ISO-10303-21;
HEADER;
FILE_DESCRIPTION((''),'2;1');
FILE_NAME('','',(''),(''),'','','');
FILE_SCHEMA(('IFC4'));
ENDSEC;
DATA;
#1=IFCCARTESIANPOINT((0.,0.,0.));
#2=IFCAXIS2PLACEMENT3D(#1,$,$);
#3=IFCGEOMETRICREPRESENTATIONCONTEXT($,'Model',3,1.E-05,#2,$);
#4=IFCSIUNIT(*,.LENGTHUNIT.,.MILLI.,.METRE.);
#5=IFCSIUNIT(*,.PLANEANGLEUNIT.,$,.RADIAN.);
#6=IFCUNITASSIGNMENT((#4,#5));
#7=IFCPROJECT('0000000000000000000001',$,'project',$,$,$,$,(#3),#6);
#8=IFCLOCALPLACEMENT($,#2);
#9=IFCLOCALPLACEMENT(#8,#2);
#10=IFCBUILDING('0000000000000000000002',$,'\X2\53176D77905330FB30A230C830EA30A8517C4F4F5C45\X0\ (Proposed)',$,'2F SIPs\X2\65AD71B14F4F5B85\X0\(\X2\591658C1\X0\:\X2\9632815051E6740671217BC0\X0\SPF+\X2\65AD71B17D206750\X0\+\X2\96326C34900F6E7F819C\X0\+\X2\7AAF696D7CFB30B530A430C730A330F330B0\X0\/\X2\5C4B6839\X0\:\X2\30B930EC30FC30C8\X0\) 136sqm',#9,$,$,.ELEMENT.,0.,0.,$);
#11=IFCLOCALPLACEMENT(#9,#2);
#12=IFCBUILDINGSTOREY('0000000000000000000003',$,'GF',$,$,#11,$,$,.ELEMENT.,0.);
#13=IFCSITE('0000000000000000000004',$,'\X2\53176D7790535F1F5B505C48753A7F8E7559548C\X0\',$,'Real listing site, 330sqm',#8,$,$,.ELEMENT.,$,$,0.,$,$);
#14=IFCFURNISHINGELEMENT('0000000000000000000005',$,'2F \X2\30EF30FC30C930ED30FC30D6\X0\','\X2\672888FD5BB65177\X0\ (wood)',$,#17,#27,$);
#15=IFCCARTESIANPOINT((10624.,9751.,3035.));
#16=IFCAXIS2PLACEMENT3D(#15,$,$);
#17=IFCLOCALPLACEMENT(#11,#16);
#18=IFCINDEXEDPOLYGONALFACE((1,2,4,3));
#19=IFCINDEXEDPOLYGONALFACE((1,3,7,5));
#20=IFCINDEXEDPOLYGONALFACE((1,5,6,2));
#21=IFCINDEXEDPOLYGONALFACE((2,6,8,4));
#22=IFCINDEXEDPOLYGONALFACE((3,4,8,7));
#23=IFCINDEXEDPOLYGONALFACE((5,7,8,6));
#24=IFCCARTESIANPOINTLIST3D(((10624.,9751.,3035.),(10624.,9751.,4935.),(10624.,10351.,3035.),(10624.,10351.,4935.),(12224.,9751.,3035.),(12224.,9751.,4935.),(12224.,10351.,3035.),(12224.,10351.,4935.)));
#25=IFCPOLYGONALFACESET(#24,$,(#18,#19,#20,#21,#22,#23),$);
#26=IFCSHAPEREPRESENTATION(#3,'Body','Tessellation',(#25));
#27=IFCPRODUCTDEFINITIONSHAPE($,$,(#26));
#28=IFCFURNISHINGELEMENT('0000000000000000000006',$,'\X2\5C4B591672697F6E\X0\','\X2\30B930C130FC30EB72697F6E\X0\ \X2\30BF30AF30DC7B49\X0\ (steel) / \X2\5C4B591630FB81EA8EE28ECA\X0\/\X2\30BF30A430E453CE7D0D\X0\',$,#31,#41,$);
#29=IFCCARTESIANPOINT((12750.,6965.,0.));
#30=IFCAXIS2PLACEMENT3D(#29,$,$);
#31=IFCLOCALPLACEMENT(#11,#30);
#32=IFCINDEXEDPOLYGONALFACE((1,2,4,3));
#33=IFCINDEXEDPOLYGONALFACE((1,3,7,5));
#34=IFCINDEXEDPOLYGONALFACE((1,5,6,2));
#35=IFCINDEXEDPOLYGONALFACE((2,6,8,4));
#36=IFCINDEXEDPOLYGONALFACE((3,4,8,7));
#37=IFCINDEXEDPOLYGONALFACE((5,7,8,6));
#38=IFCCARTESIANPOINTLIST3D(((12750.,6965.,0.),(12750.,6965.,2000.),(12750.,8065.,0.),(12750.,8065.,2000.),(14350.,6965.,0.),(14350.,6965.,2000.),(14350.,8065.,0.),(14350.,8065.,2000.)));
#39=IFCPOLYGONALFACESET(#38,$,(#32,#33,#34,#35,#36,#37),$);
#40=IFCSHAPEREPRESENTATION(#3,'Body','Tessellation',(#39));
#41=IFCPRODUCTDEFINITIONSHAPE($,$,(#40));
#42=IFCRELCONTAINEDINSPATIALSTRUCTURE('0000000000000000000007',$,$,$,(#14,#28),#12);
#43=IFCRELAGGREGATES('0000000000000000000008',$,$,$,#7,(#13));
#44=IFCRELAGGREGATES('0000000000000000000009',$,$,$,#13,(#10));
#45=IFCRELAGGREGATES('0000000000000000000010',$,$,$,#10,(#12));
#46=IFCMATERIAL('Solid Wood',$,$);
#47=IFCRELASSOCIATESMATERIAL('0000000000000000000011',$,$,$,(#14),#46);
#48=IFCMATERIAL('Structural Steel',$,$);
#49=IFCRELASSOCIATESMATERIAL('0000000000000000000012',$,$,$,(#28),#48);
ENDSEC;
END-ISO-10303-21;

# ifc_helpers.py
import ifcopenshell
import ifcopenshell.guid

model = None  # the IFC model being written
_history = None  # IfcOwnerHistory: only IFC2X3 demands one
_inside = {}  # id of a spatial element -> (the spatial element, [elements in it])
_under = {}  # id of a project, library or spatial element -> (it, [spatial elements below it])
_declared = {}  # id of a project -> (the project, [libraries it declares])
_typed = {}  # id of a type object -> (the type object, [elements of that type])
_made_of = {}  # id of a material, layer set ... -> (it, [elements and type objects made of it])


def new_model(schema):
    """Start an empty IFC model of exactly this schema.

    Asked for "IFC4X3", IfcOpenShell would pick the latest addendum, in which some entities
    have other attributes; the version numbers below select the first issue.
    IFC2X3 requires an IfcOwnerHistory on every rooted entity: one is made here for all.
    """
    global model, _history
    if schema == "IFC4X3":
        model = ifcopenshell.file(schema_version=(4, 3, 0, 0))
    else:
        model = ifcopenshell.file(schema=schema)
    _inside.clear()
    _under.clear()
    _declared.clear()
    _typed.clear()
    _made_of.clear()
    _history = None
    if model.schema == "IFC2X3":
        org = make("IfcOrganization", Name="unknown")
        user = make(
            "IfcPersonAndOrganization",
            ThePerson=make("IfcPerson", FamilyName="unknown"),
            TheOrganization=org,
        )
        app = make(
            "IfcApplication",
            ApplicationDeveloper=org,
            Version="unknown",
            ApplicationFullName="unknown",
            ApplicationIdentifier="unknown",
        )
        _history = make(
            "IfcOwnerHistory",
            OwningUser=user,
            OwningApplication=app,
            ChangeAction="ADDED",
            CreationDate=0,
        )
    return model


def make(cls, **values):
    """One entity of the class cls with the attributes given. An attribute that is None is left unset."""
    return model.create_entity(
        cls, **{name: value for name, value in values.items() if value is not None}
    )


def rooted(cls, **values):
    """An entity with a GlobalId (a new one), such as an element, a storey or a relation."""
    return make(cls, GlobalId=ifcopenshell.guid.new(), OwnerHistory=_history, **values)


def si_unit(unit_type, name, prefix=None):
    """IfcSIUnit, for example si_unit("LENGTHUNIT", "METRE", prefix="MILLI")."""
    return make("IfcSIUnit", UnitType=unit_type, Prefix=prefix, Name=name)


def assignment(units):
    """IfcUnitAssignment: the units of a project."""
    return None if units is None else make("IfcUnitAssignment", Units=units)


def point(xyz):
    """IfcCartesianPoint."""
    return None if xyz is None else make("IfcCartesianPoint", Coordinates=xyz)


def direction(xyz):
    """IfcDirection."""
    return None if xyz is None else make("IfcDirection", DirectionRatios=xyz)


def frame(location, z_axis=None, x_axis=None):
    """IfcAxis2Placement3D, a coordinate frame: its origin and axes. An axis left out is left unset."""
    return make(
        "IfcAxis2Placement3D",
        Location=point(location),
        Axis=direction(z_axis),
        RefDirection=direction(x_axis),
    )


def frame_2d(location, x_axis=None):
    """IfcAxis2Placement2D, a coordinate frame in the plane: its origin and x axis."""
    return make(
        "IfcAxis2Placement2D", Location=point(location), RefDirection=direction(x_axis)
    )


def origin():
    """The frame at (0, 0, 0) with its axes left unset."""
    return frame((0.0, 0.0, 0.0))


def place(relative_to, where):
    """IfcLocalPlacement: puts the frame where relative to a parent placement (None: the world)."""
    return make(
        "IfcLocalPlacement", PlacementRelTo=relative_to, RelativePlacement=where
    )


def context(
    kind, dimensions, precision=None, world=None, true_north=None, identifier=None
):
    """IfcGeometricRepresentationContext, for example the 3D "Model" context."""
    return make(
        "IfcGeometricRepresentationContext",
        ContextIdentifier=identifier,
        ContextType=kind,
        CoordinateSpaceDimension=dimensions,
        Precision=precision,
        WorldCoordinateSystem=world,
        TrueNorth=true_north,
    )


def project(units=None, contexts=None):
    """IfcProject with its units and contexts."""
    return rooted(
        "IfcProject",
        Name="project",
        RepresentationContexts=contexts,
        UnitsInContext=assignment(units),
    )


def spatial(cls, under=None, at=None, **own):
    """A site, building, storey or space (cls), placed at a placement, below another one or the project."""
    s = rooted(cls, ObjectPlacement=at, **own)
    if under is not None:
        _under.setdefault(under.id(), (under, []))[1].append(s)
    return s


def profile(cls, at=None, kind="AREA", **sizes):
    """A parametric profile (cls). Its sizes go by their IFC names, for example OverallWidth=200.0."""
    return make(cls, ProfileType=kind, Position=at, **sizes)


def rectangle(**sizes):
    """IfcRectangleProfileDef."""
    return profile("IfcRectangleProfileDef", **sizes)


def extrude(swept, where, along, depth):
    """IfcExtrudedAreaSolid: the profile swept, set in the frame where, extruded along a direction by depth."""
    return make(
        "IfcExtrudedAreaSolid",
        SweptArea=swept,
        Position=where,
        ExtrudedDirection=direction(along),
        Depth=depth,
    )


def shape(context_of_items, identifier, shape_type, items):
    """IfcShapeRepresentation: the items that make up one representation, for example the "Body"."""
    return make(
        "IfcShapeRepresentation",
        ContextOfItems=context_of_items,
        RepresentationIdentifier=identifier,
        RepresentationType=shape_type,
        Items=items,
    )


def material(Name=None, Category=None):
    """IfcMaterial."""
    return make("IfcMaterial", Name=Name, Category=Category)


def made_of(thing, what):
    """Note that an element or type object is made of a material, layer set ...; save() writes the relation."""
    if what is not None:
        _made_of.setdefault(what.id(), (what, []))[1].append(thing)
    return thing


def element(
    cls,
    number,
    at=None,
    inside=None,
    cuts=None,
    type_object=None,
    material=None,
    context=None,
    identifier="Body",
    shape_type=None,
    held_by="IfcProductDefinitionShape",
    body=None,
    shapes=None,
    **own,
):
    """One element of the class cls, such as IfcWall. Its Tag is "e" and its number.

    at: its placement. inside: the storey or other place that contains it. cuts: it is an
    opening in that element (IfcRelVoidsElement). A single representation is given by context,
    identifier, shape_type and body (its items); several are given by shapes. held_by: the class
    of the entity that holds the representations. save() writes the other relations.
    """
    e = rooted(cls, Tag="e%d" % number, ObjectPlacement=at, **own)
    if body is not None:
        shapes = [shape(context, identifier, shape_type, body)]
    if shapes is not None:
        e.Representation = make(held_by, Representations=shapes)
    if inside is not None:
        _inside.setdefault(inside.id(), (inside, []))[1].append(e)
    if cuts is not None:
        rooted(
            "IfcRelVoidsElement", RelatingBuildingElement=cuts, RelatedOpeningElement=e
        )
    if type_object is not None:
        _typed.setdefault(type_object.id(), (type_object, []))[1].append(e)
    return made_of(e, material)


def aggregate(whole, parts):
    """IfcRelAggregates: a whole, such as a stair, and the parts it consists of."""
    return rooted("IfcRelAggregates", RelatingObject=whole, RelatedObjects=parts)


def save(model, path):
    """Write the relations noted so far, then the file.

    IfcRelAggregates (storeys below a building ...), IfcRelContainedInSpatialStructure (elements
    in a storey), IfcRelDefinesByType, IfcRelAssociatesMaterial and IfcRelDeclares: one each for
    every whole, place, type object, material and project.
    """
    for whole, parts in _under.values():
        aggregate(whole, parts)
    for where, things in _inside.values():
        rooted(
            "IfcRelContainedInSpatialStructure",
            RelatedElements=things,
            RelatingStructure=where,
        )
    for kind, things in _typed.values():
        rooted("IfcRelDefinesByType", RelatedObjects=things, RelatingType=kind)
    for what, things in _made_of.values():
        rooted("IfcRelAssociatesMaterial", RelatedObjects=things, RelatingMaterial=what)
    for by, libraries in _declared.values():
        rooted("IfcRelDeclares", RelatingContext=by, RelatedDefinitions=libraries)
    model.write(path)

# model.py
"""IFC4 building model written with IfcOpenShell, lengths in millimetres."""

from ifc_helpers import new_model, si_unit, frame, frame_2d, origin, place, context, project, spatial, rectangle, extrude, material, element, save


model = new_model("IFC4")

# Units and contexts
model_context = context("Model", 3, precision=1e-05, world=origin())
ifc_project = project(units=[si_unit("LENGTHUNIT", "METRE", prefix="MILLI"), si_unit("PLANEANGLEUNIT", "RADIAN")], contexts=[model_context])

# Site, building, storey
site_placement = place(None, origin())
site = spatial("IfcSite", under=ifc_project, at=site_placement, Name="北海道弟子屈町美留和", ObjectType="Real listing site, 330sqm", CompositionType="ELEMENT", RefElevation=0.0)
building_placement = place(site_placement, origin())
building = spatial("IfcBuilding", under=site, at=building_placement, Name="北海道・アトリエ兼住居 (Proposed)", ObjectType="2F SIPs断熱住宅(外壁:防腐処理無節SPF+断熱素材+防水透湿膜+窯業系サイディング/屋根:スレート) 136sqm", CompositionType="ELEMENT", ElevationOfRefHeight=0.0, ElevationOfTerrain=0.0)
storey_placement = place(building_placement, origin())
storey = spatial("IfcBuildingStorey", under=building, at=storey_placement, Name="GF", CompositionType="ELEMENT", Elevation=0.0)

# Shared definitions
ifc_material_1 = material(Name="Solid Wood")

# Shared definitions
ifc_material_2 = material(Name="Structural Steel")

# Furnishing elements
furnishing_1_placement = place(storey_placement, frame((10624.0, 9751.0, 3035.0)))
element("IfcFurnishingElement", 1, at=furnishing_1_placement, inside=storey, material=ifc_material_1, Name="2F ワードローブ", Description="木製家具 (wood)", context=model_context, shape_type="SweptSolid", body=[
    extrude(rectangle(XDim=1600.0, YDim=600.0, at=frame_2d((800.0, 300.0))), frame((10624.0, 9751.0, 3035.0)), (0.0, 0.0, 1.0), 1900.0),
])
furnishing_2_placement = place(storey_placement, frame((12750.0, 6965.0, 0.0)))
element("IfcFurnishingElement", 2, at=furnishing_2_placement, inside=storey, material=ifc_material_2, Name="屋外物置", Description="スチール物置 タクボ等 (steel) / 屋外・自転車/タイヤ収納", context=model_context, shape_type="SweptSolid", body=[
    extrude(rectangle(XDim=1600.0, YDim=1100.0, at=frame_2d((800.0, 550.0))), frame((12750.0, 6965.0, 0.0)), (0.0, 0.0, 1.0), 2000.0),
])

save(model, "model.ifc")
